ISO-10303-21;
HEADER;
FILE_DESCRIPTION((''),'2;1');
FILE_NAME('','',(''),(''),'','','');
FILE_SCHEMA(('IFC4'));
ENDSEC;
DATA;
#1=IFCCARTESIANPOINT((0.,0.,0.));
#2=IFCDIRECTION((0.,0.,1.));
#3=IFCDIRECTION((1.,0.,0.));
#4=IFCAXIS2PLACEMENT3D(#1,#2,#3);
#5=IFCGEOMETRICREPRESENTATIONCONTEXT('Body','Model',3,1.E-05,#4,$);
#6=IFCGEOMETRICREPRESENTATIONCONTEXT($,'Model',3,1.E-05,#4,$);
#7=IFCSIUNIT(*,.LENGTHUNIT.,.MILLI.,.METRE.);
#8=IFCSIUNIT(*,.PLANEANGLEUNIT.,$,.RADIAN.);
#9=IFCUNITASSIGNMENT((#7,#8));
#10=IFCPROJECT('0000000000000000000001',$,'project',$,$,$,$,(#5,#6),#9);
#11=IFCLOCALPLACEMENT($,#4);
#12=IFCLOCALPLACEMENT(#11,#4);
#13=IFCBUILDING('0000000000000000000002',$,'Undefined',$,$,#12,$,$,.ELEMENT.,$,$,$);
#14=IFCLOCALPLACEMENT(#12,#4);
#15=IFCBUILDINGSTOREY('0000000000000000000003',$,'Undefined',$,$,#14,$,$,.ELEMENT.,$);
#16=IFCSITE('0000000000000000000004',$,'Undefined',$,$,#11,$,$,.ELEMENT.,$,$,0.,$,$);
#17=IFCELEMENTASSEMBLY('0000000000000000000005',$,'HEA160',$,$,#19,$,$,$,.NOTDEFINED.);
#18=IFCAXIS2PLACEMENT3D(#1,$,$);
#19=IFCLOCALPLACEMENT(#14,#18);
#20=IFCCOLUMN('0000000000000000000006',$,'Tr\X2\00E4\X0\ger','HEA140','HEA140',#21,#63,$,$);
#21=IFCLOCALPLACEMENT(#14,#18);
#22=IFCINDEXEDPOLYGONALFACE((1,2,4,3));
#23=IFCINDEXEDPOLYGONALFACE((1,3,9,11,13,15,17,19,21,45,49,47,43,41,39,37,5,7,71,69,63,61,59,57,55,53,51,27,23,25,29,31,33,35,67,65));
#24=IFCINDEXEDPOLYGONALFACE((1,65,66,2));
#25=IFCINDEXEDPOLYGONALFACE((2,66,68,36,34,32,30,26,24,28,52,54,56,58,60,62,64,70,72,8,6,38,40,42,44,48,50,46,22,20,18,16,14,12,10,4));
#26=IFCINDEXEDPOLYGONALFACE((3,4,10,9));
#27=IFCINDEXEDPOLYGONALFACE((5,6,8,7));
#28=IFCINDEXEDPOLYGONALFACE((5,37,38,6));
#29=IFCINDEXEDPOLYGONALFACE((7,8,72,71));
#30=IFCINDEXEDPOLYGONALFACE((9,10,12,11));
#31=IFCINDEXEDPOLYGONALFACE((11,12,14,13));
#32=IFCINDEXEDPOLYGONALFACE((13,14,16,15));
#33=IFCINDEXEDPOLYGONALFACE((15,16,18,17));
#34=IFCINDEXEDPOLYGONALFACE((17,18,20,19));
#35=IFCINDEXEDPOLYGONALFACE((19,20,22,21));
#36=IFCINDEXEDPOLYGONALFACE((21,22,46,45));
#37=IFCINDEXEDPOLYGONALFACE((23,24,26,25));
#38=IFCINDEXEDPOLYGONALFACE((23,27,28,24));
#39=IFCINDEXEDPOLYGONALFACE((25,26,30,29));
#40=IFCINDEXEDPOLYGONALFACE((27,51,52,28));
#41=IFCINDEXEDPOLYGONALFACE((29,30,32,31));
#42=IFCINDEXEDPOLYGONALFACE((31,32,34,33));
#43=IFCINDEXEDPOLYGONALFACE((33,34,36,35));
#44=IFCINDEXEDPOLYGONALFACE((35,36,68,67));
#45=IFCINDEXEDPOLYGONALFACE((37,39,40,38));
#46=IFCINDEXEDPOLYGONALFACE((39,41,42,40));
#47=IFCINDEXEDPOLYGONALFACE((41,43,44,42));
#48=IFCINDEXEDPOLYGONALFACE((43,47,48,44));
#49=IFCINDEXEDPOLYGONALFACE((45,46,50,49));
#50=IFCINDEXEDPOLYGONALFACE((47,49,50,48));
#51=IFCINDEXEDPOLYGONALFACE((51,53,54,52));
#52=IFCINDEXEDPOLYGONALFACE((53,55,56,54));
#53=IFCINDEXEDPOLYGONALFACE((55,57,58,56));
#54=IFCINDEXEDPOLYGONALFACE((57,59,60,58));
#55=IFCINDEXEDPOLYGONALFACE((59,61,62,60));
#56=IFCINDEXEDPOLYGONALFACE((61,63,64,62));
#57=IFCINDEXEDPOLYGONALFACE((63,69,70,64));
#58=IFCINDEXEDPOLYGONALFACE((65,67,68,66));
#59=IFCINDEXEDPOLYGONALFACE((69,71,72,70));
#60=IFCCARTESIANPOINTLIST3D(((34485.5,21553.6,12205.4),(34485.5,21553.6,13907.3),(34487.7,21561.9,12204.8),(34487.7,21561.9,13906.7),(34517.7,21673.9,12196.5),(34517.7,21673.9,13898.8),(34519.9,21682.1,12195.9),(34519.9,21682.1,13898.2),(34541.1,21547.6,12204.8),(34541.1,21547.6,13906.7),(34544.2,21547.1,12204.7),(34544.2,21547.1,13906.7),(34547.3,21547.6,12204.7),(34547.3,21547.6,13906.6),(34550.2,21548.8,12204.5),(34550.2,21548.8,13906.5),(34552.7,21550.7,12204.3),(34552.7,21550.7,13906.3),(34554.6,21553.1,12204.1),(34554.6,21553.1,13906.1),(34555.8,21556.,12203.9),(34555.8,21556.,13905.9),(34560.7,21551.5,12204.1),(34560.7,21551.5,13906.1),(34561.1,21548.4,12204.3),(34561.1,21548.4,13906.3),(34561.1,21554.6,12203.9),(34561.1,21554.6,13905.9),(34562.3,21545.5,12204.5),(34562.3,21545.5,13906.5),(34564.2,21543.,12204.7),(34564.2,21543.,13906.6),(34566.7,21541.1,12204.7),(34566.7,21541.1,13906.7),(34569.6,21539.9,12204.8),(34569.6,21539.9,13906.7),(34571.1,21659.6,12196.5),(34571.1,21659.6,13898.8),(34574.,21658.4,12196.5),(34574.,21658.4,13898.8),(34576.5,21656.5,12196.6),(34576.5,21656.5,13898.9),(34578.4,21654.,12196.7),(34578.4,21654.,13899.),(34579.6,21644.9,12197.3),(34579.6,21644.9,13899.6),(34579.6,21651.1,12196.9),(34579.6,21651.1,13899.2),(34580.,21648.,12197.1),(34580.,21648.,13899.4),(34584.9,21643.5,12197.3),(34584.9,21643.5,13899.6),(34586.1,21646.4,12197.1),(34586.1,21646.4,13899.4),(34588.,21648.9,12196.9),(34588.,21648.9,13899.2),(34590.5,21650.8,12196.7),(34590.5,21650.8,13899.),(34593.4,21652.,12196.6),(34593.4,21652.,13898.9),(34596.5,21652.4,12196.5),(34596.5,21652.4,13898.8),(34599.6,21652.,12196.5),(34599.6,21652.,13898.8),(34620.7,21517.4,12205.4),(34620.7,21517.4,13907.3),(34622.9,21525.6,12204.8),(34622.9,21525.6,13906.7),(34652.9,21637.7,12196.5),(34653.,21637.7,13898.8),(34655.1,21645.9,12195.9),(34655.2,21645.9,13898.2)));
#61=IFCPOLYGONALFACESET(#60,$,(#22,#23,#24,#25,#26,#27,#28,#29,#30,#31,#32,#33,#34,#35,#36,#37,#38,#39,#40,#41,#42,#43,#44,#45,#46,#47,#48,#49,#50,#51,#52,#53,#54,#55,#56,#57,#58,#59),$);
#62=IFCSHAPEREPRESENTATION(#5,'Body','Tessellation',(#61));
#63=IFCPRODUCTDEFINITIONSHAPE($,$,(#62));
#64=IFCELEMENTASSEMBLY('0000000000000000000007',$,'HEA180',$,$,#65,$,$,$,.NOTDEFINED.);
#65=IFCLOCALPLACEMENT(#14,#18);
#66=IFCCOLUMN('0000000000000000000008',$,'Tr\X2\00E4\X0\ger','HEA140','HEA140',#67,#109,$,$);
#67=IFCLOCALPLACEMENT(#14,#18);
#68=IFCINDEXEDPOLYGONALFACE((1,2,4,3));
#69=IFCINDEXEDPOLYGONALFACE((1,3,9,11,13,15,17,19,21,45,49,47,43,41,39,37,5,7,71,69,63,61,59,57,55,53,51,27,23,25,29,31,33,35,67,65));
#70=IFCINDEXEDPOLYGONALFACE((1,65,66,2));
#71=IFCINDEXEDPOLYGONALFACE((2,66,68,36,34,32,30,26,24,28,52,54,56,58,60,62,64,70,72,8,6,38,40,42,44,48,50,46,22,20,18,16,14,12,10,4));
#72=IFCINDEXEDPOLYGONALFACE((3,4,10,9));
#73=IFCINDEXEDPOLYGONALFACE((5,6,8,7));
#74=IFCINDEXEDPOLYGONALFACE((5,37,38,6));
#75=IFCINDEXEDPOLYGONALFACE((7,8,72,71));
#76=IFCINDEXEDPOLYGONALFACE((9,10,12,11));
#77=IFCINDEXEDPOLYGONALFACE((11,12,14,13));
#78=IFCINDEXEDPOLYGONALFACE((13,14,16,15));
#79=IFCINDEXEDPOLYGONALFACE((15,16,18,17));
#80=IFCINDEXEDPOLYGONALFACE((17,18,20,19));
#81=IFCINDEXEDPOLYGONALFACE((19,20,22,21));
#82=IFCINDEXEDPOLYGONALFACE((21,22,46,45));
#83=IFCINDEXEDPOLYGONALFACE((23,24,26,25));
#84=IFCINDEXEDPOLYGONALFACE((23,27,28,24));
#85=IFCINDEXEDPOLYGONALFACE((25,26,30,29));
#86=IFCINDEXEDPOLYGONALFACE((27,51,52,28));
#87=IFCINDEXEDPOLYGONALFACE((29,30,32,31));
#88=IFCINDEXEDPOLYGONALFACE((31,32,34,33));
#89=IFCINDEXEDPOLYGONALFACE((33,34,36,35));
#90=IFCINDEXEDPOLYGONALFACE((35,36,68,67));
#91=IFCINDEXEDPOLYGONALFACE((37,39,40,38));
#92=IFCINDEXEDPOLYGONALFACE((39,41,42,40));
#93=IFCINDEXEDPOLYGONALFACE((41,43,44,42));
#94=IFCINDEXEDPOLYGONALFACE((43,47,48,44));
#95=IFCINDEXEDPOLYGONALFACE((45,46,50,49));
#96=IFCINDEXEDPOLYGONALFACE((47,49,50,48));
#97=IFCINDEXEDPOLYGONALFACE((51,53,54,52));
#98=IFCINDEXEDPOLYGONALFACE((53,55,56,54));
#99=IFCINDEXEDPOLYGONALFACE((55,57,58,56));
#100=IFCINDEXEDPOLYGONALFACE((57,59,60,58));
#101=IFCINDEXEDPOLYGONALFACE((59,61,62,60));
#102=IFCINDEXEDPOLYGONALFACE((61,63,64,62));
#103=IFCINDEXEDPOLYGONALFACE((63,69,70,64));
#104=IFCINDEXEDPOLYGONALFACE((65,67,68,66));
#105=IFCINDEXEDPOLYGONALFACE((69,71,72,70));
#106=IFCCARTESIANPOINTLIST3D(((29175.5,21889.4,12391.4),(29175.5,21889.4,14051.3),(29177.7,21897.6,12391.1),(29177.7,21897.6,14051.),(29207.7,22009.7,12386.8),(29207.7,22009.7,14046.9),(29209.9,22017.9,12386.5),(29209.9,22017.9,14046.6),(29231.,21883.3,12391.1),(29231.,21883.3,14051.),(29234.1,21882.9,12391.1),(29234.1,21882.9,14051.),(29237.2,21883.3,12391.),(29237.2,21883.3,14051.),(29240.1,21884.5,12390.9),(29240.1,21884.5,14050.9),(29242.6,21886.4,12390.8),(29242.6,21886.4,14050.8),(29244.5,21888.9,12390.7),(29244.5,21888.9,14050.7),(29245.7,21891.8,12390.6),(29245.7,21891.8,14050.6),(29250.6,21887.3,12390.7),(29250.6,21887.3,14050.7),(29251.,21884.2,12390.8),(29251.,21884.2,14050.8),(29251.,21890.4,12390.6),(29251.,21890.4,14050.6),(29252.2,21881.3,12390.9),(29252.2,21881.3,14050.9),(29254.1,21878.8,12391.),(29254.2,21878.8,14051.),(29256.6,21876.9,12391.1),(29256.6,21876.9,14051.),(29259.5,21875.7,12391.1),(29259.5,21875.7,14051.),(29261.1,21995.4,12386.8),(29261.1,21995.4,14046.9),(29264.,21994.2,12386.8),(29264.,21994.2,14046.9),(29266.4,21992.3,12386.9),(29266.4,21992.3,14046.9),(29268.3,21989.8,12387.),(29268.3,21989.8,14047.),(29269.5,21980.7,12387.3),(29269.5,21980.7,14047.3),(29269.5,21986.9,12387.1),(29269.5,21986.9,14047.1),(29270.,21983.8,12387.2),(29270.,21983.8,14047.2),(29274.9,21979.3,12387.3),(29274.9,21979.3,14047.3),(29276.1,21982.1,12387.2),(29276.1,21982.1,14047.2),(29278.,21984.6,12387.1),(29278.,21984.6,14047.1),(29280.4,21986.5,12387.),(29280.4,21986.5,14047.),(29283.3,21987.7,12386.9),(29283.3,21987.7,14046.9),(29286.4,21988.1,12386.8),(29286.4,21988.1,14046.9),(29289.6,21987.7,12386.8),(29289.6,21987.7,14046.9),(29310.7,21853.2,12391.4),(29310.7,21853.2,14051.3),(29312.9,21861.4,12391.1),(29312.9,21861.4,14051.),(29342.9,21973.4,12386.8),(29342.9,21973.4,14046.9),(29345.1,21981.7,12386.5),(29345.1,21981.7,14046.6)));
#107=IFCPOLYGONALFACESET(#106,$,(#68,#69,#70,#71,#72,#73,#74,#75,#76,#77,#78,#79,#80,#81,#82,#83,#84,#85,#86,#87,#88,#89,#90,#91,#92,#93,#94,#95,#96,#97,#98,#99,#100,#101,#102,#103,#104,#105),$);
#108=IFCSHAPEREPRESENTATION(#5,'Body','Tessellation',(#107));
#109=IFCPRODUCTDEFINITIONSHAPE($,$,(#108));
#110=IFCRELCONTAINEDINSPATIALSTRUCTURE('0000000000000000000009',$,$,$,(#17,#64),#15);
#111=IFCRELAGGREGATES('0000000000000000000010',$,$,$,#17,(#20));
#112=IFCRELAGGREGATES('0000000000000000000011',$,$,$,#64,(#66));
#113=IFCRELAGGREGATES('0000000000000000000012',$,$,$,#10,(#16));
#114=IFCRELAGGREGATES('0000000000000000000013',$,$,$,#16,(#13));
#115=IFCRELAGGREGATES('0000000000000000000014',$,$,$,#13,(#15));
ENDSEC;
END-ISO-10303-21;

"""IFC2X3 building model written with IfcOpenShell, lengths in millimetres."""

from ifc_helpers import new_model, si_unit, frame, origin_with_axes, origin_2d_with_axis, place, context, project, spatial, i_section, extrude, clip, halfspace, element, aggregate, save


model = new_model("IFC2X3")

# Units and contexts
model_context_1 = context("Model", 3, precision=1e-05, world=origin_with_axes(), identifier="Body")
model_context_2 = context("Model", 3, precision=1e-05, world=origin_with_axes())
ifc_project = project(units=[si_unit("LENGTHUNIT", "METRE", prefix="MILLI"), si_unit("PLANEANGLEUNIT", "RADIAN")], contexts=[model_context_1, model_context_2])

# Site, building, storey
site_placement = place(None, origin_with_axes())
site = spatial("IfcSite", under=ifc_project, at=site_placement, Name="Undefined", CompositionType="ELEMENT", RefElevation=0.0)
building_placement = place(site_placement, origin_with_axes())
building = spatial("IfcBuilding", under=site, at=building_placement, Name="Undefined", CompositionType="ELEMENT")
storey_placement = place(building_placement, origin_with_axes())
storey = spatial("IfcBuildingStorey", under=building, at=storey_placement, Name="Undefined", CompositionType="ELEMENT")

# Element assemblies, columns
assembly_1 = element("IfcElementAssembly", 1, inside=storey, Name="HEA160", PredefinedType="NOTDEFINED")
column_1_placement = place(storey_placement, frame((34570.3, 21599.8, 12124.6), z_axis=(0.0, 0.0, 1.0), x_axis=(1.0, 0.0, 0.0)))
column_1 = element("IfcColumn", 2, at=column_1_placement, Name="Träger", Description="HEA140", ObjectType="HEA140", context=model_context_1, shape_type="Clipping", body=[
    clip(clip(extrude(i_section(OverallWidth=140.0, OverallDepth=133.0, WebThickness=5.5, FlangeThickness=8.5, FilletRadius=12.0, at=origin_2d_with_axis()), frame((0.0, 0.0, 1787.5), z_axis=(0.0, 0.0, -1.0), x_axis=(-0.965926, 0.258819, 0.0)), (0.0, 0.0, 1.0), 1720.9), halfspace(frame((17.2, 64.2, 1773.6), z_axis=(-0.017603, -0.065694, -0.997685), x_axis=(-0.25822, -0.963689, 0.068011)), True)), halfspace(frame((0.0, 0.0, 76.1), z_axis=(-0.018434, -0.068798, -0.99746), x_axis=(-0.258162, -0.963473, 0.071225)), False)),
])
aggregate(assembly_1, [column_1])
assembly_2 = element("IfcElementAssembly", 3, inside=storey, Name="HEA180", PredefinedType="NOTDEFINED")
column_2_placement = place(storey_placement, frame((29260.3, 21935.5, 12303.5), z_axis=(0.0, 0.0, 1.0), x_axis=(1.0, 0.0, 0.0)))
column_2 = element("IfcColumn", 4, at=column_2_placement, Name="Träger", Description="HEA140", ObjectType="HEA140", context=model_context_1, shape_type="Clipping", body=[
    clip(clip(extrude(i_section(OverallWidth=140.0, OverallDepth=133.0, WebThickness=5.5, FlangeThickness=8.5, FilletRadius=12.0, at=origin_2d_with_axis()), frame((0.0, 0.0, 1750.3), z_axis=(0.0, 0.0, -1.0), x_axis=(-0.965926, 0.258819, 0.0)), (0.0, 0.0, 1.0), 1669.7), halfspace(frame((0.0, 0.0, 85.4), z_axis=(-0.00944, -0.035231, -0.999335), x_axis=(-0.258647, -0.965283, 0.036474)), False)), halfspace(frame((-17.2, -64.2, 1747.8), z_axis=(0.009248, 0.034513, 0.999361), x_axis=(0.258654, 0.965309, -0.03573)), False)),
])
aggregate(assembly_2, [column_2])

save(model, "model.ifc")
